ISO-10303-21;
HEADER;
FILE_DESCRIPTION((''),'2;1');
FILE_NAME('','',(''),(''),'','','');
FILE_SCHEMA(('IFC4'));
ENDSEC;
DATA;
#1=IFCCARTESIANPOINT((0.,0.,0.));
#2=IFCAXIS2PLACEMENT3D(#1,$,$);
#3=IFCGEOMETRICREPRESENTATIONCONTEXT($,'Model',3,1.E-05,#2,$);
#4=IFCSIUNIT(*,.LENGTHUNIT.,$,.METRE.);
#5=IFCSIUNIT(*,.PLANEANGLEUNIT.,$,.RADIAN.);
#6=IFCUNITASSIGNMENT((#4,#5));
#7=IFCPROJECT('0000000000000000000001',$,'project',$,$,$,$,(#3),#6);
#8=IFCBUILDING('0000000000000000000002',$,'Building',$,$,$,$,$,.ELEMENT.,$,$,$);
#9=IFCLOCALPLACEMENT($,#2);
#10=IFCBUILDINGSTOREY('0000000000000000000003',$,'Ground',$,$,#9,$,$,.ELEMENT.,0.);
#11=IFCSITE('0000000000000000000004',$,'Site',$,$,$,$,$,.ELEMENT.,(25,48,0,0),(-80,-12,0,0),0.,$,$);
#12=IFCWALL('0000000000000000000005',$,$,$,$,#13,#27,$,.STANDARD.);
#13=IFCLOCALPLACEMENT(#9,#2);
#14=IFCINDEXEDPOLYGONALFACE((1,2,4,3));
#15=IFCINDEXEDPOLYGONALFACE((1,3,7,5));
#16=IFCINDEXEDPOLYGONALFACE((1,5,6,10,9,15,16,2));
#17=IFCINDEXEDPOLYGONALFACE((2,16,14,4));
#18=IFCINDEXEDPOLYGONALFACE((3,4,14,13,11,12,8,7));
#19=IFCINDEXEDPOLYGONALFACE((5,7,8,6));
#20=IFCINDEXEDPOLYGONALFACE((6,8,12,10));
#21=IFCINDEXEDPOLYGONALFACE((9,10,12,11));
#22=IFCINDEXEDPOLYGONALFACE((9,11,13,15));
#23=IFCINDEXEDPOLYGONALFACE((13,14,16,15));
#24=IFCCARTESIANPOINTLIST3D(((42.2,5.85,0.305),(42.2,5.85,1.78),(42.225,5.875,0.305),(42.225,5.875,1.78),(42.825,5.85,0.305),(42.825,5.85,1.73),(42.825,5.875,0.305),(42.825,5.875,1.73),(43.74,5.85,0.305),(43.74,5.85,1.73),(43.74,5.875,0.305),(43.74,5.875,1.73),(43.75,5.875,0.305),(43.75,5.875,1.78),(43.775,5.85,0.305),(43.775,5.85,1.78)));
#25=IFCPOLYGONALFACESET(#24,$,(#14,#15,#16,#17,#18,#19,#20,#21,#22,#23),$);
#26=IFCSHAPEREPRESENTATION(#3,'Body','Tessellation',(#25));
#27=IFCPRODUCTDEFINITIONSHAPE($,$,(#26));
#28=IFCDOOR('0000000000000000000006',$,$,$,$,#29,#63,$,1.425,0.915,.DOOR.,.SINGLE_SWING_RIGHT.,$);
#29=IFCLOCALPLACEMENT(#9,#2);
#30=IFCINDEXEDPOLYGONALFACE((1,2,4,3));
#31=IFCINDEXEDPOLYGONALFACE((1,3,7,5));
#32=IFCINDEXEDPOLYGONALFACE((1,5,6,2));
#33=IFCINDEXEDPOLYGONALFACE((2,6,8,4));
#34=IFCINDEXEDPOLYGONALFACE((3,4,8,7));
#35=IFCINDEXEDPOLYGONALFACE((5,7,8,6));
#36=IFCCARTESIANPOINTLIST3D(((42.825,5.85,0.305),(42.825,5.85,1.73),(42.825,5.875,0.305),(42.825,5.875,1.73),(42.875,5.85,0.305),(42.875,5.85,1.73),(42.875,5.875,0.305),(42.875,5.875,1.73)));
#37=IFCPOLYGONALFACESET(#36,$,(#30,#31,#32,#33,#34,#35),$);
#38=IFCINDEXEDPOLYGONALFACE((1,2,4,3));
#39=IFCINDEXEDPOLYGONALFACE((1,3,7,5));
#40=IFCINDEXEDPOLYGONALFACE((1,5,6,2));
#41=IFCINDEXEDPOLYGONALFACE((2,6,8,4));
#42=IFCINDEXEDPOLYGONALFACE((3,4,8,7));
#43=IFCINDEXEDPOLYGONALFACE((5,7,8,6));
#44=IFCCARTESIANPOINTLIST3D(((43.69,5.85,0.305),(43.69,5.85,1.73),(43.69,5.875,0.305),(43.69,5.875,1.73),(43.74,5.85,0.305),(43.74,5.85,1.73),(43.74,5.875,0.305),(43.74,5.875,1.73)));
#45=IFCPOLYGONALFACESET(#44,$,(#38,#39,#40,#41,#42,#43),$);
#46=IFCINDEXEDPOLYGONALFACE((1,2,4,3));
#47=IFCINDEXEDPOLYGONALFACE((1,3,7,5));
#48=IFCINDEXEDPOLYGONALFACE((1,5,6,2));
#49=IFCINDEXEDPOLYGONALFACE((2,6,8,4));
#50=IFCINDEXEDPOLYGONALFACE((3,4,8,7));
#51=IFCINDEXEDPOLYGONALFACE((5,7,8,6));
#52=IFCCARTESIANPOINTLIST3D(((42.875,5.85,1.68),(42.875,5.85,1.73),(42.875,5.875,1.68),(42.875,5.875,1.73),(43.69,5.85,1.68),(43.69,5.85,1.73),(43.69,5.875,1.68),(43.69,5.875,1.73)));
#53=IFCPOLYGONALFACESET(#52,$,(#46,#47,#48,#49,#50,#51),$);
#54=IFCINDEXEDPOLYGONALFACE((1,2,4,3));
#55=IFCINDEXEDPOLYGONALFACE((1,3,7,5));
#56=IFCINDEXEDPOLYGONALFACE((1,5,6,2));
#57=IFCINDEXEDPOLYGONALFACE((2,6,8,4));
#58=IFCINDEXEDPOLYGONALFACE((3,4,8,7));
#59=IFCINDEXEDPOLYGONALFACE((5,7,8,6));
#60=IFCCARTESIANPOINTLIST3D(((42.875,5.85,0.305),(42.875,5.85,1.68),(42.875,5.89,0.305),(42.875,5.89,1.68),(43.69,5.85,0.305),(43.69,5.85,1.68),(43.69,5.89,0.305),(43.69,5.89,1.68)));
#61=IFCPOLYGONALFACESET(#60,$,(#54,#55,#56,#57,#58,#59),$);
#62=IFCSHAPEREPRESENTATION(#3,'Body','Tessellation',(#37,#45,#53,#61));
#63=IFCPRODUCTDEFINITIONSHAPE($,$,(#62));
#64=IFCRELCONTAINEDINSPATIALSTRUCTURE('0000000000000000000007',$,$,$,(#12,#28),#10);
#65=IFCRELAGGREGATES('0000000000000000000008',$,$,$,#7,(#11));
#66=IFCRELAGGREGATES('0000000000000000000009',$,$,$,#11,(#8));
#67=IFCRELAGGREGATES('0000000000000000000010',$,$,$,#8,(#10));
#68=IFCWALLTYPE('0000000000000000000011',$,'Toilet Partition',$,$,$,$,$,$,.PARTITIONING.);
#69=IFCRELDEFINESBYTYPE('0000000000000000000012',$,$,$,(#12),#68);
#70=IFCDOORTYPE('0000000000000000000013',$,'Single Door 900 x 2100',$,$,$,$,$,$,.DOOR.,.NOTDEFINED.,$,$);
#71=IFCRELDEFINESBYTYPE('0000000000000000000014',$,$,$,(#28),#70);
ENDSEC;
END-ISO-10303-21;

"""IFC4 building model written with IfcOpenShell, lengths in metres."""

from ifc_helpers import new_model, si_unit, frame, frame_2d, origin, origin_with_axes, origin_2d, place, context, project, spatial, polyline, rectangle, outline, extrude, type_object, element, fill, save


model = new_model("IFC4")

# Units and contexts
model_context = context("Model", 3, precision=1e-05, world=origin())
ifc_project = project(units=[si_unit("LENGTHUNIT", "METRE"), si_unit("PLANEANGLEUNIT", "RADIAN")], contexts=[model_context])

# Site, building, storey
site = spatial("IfcSite", under=ifc_project, Name="Site", CompositionType="ELEMENT", RefLatitude=(25, 48, 0, 0), RefLongitude=(-80, -12, 0, 0), RefElevation=0.0)
building = spatial("IfcBuilding", under=site, Name="Building", CompositionType="ELEMENT")
storey_placement = place(None, origin())
storey = spatial("IfcBuildingStorey", under=building, at=storey_placement, Name="Ground", CompositionType="ELEMENT", Elevation=0.0)

# Shared definitions
door_type = type_object("IfcDoorType", Name="Single Door 900 x 2100", OperationType="NOTDEFINED", PredefinedType="DOOR")

# Shared definitions
wall_type_1 = type_object("IfcWallType", Name="Toilet Partition", PredefinedType="PARTITIONING")

# Wall, opening, door
wall_1_placement = place(None, frame((42.225, 5.8625, 0.305), z_axis=(0.0, 0.0, 1.0), x_axis=(1.0, 0.0, 0.0)))
wall_1 = element("IfcWall", 1, at=wall_1_placement, inside=storey, type_object=wall_type_1, PredefinedType="STANDARD", context=model_context, shape_type="SweptSolid", body=[
    extrude(outline(polyline([(-0.025, -0.0125), (1.55, -0.0125), (1.525, 0.0125), (0.0, 0.0125), (-0.025, -0.0125)])), origin(), (0.0, 0.0, 1.0), 1.475),
])
opening_1_placement = place(wall_1_placement, frame((1.0575, 0.0, 0.0), z_axis=(0.0, 0.0, 1.0), x_axis=(1.0, 0.0, 0.0)))
opening_1 = element("IfcOpeningElement", 2, at=opening_1_placement, cuts=wall_1, PredefinedType="OPENING", context=model_context, shape_type="SweptSolid", body=[
    extrude(rectangle(XDim=0.915, YDim=0.027, at=origin_2d()), origin(), (0.0, 0.0, 1.0), 1.425),
])
door_1_placement = place(opening_1_placement, origin_with_axes())
door_1 = element("IfcDoor", 3, at=door_1_placement, inside=storey, type_object=door_type, OperationType="SINGLE_SWING_RIGHT", OverallHeight=1.425, OverallWidth=0.915, PredefinedType="DOOR", context=model_context, shape_type="SweptSolid", body=[
    extrude(rectangle(XDim=0.05, YDim=0.025, at=frame_2d((-0.4325, 0.0))), origin(), (0.0, 0.0, 1.0), 1.425),
    extrude(rectangle(XDim=0.05, YDim=0.025, at=frame_2d((0.4325, 0.0))), origin(), (0.0, 0.0, 1.0), 1.425),
    extrude(rectangle(XDim=0.815, YDim=0.025, at=origin_2d()), frame((0.0, 0.0, 1.375)), (0.0, 0.0, 1.0), 0.05),
    extrude(rectangle(XDim=0.815, YDim=0.04, at=frame_2d((0.0, 0.0075))), origin(), (0.0, 0.0, 1.0), 1.375),
])
fill(opening_1, door_1)

save(model, "model.ifc")
